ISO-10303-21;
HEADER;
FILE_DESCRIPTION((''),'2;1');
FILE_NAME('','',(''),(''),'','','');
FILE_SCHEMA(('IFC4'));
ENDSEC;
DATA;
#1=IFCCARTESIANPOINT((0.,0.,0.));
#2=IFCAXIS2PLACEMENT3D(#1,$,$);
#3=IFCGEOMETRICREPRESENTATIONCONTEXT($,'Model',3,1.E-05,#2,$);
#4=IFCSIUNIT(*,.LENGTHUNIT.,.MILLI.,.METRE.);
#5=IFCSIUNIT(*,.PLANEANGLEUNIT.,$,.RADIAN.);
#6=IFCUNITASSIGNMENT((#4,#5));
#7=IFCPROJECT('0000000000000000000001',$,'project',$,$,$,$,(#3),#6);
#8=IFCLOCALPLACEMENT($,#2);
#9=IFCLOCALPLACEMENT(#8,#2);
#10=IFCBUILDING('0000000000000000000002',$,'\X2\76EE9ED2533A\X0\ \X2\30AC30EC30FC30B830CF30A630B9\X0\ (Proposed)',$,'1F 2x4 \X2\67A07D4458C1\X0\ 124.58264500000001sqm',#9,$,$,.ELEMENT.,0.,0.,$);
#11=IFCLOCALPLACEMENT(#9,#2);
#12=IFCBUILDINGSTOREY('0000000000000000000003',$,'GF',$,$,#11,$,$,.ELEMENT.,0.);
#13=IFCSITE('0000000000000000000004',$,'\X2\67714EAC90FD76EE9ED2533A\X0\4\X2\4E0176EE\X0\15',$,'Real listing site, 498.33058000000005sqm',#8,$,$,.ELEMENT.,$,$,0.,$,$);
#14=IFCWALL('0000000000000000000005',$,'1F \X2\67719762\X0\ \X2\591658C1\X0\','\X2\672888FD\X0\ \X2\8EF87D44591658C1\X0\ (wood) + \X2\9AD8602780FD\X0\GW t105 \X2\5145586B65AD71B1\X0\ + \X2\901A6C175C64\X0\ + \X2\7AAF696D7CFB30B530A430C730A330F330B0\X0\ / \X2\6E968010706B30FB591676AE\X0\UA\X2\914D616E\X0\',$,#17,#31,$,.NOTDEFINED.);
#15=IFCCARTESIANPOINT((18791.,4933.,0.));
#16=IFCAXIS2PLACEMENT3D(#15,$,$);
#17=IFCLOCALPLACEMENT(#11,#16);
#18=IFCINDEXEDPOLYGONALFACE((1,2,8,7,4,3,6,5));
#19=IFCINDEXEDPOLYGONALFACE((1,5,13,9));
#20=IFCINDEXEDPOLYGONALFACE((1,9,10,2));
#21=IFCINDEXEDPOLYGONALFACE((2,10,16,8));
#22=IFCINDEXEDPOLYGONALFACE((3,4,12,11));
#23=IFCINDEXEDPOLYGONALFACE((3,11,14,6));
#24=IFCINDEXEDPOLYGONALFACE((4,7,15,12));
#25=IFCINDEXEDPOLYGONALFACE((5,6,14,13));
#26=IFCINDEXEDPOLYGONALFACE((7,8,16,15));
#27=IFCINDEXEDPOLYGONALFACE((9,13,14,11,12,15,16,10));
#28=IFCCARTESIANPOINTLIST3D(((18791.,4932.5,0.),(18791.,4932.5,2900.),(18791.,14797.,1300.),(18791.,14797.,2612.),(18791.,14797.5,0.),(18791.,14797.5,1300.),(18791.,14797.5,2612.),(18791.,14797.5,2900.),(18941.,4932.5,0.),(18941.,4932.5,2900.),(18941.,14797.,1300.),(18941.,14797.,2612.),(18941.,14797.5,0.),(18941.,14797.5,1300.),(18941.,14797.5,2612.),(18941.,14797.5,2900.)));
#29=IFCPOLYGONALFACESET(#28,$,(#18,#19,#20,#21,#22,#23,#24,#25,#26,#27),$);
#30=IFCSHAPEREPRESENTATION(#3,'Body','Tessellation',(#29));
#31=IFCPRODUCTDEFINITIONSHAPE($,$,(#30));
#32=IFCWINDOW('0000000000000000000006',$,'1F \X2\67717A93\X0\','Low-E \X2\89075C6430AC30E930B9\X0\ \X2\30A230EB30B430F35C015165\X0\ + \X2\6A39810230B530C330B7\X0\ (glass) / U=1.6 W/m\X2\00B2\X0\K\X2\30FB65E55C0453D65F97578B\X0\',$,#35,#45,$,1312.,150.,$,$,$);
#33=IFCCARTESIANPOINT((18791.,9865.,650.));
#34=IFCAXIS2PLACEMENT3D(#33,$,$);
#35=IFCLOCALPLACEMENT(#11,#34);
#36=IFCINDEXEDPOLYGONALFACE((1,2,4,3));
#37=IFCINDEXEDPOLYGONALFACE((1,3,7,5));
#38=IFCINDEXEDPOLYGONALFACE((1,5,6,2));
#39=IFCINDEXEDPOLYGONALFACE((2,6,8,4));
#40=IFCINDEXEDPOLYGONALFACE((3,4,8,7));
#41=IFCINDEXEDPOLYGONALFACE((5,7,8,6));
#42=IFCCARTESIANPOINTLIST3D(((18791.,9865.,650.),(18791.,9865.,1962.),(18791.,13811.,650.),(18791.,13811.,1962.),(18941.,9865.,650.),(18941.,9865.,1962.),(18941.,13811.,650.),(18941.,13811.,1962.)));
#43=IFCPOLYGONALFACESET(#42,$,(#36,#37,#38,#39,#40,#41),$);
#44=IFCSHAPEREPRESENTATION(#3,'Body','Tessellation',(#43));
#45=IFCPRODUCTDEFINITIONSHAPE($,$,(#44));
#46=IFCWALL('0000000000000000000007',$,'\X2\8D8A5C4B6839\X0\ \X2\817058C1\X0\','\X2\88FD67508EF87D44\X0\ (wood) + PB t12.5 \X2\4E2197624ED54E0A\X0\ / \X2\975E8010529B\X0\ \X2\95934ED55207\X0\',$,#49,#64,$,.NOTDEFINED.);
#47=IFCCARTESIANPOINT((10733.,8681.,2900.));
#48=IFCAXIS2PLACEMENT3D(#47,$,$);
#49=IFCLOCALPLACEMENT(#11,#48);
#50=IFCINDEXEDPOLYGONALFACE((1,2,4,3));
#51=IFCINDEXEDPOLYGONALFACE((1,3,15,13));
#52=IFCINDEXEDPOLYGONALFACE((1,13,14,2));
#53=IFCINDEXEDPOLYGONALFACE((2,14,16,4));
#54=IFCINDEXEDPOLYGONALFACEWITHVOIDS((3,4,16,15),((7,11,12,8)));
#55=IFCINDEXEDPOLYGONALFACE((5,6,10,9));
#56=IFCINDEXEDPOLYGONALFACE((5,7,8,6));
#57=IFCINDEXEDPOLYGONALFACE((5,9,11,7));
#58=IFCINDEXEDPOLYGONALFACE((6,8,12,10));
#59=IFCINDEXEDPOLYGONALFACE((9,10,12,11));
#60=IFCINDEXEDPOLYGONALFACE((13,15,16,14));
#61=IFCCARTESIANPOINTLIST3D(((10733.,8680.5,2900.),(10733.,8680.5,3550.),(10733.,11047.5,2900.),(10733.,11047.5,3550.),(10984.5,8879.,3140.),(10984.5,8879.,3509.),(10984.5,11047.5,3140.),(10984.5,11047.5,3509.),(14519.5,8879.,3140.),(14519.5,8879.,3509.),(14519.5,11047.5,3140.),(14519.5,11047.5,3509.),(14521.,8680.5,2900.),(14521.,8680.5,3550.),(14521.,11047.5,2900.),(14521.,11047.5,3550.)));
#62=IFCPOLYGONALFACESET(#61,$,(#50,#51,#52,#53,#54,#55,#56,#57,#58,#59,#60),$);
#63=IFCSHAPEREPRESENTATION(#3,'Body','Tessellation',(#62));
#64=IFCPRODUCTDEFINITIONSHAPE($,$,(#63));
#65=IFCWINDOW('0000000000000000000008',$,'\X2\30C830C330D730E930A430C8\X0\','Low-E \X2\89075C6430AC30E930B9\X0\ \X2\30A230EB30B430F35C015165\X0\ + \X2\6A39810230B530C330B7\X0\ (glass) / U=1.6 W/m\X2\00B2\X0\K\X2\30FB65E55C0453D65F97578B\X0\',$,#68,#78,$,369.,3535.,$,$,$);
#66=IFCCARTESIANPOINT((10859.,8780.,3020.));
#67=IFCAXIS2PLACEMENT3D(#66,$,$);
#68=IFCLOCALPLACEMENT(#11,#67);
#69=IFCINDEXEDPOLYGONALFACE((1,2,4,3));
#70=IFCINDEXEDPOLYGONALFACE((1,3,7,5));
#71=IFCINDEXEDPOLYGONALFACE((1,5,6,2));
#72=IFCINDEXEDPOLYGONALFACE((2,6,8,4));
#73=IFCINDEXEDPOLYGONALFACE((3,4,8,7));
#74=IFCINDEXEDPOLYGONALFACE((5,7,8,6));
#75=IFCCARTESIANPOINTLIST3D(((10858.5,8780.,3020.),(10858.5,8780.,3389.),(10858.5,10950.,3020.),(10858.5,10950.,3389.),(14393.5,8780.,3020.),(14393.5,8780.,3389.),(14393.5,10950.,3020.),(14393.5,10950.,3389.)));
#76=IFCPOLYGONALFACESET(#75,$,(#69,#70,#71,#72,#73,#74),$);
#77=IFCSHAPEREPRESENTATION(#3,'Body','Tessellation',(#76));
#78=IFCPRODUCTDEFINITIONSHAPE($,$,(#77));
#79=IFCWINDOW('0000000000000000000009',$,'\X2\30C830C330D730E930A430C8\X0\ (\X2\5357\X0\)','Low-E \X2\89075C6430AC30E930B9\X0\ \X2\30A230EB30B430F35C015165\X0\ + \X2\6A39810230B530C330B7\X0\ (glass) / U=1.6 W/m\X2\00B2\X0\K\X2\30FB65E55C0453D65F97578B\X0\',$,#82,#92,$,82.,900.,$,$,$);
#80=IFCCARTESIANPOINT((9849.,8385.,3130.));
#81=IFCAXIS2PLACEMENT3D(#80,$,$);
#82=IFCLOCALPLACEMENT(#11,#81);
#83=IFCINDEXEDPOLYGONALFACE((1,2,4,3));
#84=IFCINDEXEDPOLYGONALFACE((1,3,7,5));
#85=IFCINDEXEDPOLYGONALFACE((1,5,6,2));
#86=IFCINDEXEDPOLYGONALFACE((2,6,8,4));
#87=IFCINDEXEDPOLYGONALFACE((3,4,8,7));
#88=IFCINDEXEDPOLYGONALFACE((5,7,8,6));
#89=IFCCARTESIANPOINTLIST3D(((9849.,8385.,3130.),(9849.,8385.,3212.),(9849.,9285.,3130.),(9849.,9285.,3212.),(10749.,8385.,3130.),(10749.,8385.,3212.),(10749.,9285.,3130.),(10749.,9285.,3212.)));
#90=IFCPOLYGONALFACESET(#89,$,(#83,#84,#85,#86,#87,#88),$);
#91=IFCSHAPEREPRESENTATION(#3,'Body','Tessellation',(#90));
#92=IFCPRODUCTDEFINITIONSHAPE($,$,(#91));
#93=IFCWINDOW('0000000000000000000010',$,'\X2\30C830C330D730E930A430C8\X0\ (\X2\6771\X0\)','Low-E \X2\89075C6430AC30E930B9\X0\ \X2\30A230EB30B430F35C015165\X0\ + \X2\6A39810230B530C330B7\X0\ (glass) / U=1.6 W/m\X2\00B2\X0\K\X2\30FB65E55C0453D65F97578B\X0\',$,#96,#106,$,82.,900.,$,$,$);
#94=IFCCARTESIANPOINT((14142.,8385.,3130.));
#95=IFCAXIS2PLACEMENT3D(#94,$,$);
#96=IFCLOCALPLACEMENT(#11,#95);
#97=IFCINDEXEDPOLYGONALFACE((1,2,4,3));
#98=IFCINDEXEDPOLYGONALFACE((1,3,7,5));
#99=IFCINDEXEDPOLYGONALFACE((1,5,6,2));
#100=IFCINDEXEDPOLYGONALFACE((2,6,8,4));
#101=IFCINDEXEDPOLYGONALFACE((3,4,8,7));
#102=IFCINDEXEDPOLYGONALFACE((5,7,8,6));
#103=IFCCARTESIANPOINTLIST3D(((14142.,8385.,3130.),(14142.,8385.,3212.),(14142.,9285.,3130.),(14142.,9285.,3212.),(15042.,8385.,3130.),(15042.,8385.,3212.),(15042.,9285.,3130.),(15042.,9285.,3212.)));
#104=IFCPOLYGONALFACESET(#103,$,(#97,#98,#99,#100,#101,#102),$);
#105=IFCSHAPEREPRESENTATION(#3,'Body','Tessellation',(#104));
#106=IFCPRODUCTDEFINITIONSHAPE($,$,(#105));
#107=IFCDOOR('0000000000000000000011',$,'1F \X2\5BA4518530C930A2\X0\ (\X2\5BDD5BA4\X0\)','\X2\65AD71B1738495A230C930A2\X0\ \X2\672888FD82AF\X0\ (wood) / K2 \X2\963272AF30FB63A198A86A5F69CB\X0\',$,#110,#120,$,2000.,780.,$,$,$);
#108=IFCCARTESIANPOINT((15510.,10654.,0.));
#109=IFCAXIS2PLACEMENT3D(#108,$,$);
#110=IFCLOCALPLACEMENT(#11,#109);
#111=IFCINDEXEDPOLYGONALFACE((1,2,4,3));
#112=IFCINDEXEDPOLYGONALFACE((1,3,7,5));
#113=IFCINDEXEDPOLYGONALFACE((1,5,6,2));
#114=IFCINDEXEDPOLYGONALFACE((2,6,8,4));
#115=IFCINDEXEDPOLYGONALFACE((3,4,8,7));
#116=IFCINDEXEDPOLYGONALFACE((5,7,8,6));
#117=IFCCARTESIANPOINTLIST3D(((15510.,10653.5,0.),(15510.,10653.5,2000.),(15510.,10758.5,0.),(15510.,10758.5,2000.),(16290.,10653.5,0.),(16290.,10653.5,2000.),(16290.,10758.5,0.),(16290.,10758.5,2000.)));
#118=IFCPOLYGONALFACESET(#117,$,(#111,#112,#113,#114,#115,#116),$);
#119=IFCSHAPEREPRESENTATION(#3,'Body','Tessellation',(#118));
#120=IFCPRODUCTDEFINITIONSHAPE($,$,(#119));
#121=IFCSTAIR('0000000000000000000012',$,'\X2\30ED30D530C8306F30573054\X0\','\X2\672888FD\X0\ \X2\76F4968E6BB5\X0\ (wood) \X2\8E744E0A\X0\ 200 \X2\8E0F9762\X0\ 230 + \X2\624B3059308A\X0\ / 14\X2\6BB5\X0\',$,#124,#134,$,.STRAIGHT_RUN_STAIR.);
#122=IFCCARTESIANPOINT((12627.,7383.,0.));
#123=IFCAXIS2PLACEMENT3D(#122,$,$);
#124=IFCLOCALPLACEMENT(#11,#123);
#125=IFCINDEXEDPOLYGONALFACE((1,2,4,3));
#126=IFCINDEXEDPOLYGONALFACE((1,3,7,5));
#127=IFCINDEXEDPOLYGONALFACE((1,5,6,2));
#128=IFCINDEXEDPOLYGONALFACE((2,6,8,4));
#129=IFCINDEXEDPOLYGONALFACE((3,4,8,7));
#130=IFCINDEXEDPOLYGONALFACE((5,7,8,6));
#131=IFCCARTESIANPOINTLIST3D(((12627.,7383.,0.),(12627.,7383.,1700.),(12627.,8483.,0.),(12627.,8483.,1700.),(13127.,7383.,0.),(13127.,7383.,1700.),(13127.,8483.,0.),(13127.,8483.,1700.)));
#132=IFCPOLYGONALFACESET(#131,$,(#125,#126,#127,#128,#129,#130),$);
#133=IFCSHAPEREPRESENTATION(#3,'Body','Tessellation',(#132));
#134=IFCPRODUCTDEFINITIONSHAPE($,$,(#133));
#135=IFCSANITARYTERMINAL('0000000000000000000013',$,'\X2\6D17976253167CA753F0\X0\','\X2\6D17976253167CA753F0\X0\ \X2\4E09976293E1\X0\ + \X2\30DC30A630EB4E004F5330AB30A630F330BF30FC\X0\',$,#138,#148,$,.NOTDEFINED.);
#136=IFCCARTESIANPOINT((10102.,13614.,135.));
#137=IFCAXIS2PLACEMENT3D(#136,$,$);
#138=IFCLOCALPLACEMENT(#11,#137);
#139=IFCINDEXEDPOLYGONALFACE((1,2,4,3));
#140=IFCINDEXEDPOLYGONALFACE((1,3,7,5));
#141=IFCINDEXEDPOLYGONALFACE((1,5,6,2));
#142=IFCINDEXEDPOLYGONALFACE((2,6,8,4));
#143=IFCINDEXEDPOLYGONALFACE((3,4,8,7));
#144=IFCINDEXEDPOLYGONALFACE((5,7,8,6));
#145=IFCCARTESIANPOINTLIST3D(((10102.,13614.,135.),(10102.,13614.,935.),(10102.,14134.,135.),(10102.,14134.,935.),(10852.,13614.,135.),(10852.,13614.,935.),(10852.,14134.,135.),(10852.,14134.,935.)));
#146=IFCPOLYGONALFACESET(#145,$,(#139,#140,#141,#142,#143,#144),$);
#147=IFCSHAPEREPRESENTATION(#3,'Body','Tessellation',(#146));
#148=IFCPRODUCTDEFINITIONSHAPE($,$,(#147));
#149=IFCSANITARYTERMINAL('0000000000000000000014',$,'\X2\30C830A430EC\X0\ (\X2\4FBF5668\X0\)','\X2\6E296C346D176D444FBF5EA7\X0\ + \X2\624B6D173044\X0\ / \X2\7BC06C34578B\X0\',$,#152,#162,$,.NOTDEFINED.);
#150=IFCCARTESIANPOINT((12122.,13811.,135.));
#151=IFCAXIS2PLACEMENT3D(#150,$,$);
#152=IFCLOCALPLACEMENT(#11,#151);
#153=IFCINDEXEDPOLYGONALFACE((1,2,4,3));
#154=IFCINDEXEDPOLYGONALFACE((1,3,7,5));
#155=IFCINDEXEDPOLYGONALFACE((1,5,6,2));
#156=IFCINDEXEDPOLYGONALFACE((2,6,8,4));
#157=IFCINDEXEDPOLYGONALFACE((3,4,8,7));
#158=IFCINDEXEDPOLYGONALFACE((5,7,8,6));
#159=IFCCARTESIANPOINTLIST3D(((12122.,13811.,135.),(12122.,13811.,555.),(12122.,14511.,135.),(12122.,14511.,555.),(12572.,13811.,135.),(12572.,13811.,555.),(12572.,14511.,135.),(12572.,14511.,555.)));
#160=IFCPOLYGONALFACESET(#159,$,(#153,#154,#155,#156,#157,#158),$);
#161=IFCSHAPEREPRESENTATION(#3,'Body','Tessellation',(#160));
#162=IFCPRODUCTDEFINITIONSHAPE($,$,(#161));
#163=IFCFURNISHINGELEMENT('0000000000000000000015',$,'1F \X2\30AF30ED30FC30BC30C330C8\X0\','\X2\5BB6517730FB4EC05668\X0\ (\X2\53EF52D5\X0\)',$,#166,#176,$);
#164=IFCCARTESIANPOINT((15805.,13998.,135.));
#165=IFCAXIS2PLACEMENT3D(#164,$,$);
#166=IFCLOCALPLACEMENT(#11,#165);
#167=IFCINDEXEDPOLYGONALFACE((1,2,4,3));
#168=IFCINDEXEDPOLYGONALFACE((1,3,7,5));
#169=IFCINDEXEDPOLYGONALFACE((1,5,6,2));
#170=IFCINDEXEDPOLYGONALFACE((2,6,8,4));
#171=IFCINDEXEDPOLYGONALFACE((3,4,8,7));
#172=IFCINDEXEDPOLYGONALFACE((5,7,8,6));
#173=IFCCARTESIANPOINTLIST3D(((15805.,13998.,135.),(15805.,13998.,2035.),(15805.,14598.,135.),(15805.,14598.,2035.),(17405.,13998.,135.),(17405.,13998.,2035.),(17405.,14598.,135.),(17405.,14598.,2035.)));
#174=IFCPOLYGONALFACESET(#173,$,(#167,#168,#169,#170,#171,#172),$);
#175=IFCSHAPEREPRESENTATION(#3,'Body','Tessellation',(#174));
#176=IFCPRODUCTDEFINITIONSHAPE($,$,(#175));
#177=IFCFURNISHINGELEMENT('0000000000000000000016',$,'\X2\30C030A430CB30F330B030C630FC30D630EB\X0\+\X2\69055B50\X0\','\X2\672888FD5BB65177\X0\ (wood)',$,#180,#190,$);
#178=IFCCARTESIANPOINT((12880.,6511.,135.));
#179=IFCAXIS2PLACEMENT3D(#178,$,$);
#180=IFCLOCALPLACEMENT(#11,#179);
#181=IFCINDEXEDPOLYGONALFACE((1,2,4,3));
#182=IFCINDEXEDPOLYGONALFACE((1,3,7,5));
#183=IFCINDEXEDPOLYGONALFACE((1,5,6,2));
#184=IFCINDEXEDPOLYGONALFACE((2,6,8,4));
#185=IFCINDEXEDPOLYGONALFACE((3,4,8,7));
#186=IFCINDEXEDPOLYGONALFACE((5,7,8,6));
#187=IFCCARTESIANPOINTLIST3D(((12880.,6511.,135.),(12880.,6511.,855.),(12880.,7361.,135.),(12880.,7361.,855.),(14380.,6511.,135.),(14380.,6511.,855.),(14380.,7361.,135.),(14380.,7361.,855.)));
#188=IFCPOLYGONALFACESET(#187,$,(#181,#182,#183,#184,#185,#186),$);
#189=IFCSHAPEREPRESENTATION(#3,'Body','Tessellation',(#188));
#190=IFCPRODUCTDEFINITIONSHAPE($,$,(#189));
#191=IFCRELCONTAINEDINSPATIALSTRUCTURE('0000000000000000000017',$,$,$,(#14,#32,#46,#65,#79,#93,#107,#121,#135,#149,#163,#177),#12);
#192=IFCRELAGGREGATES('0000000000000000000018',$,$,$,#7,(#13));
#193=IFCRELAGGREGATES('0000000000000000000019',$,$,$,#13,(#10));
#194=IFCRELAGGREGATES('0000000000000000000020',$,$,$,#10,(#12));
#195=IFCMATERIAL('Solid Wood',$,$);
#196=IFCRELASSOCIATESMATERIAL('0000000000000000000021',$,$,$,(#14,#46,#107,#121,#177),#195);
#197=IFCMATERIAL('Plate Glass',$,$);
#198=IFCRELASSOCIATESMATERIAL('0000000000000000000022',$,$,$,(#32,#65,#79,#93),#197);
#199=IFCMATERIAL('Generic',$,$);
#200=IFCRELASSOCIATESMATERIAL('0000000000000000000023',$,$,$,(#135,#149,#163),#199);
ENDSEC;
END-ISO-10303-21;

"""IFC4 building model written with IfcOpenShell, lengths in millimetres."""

from ifc_helpers import new_model, si_unit, frame, frame_2d, origin, place, context, project, spatial, rectangle, extrude, material, element, fill, save


model = new_model("IFC4")

# Units and contexts
model_context = context("Model", 3, precision=1e-05, world=origin())
ifc_project = project(units=[si_unit("LENGTHUNIT", "METRE", prefix="MILLI"), si_unit("PLANEANGLEUNIT", "RADIAN")], contexts=[model_context])

# Site, building, storey
site_placement = place(None, origin())
site = spatial("IfcSite", under=ifc_project, at=site_placement, Name="東京都目黒区4丁目15", ObjectType="Real listing site, 498.33058000000005sqm", CompositionType="ELEMENT", RefElevation=0.0)
building_placement = place(site_placement, origin())
building = spatial("IfcBuilding", under=site, at=building_placement, Name="目黒区 ガレージハウス (Proposed)", ObjectType="1F 2x4 枠組壁 124.58264500000001sqm", CompositionType="ELEMENT", ElevationOfRefHeight=0.0, ElevationOfTerrain=0.0)
storey_placement = place(building_placement, origin())
storey = spatial("IfcBuildingStorey", under=building, at=storey_placement, Name="GF", CompositionType="ELEMENT", Elevation=0.0)

# Wall, opening, window
ifc_material_1 = material(Name="Solid Wood")
wall_1_placement = place(storey_placement, frame((18791.0, 4933.0, 0.0)))
wall_1 = element("IfcWall", 1, at=wall_1_placement, inside=storey, material=ifc_material_1, Name="1F 東面 外壁", Description="木製 軸組外壁 (wood) + 高性能GW t105 充填断熱 + 通気層 + 窯業系サイディング / 準耐火・外皮UA配慮", PredefinedType="NOTDEFINED", context=model_context, shape_type="SweptSolid", body=[
    extrude(rectangle(XDim=150.0, YDim=9865.0, at=frame_2d((75.0, 4932.0))), frame((18791.0, 4933.0, 0.0)), (0.0, 0.0, 1.0), 2900.0),
])
opening_1_placement = place(storey_placement, frame((18791.0, 9865.0, 650.0)))
opening_1 = element("IfcOpeningElement", 2, at=opening_1_placement, cuts=wall_1, PredefinedType="NOTDEFINED", context=model_context, shape_type="SweptSolid", body=[
    extrude(rectangle(XDim=150.0, YDim=3946.0, at=frame_2d((75.0, 1973.0))), frame((18791.0, 9865.0, 650.0)), (0.0, 0.0, 1.0), 1312.0),
])
ifc_material_2 = material(Name="Plate Glass")
window_1_placement = place(storey_placement, frame((18791.0, 9865.0, 650.0)))
window_1 = element("IfcWindow", 3, at=window_1_placement, inside=storey, material=ifc_material_2, Name="1F 東窓", Description="Low-E 複層ガラス アルゴン封入 + 樹脂サッシ (glass) / U=1.6 W/m²K・日射取得型", OverallHeight=1312.0, OverallWidth=150.0, context=model_context, shape_type="SweptSolid", body=[
    extrude(rectangle(XDim=150.0, YDim=3946.0, at=frame_2d((75.0, 1973.0))), frame((18791.0, 9865.0, 650.0)), (0.0, 0.0, 1.0), 1312.0),
])
fill(opening_1, window_1)

# Wall, openings, windows
wall_2_placement = place(storey_placement, frame((10733.0, 8681.0, 2900.0)))
wall_2 = element("IfcWall", 4, at=wall_2_placement, inside=storey, material=ifc_material_1, Name="越屋根 腰壁", Description="製材軸組 (wood) + PB t12.5 両面仕上 / 非耐力 間仕切", PredefinedType="NOTDEFINED", context=model_context, shape_type="SweptSolid", body=[
    extrude(rectangle(XDim=3788.0, YDim=2367.0, at=frame_2d((1894.0, 1183.0))), frame((10733.0, 8681.0, 2900.0)), (0.0, 0.0, 1.0), 650.0),
])
opening_2_placement = place(storey_placement, frame((10859.0, 8780.0, 3020.0)))
opening_2 = element("IfcOpeningElement", 5, at=opening_2_placement, cuts=wall_2, PredefinedType="NOTDEFINED", context=model_context, shape_type="SweptSolid", body=[
    extrude(rectangle(XDim=3535.0, YDim=2170.0, at=frame_2d((1767.0, 1085.0))), frame((10859.0, 8780.0, 3020.0)), (0.0, 0.0, 1.0), 369.0),
])
opening_3_placement = place(storey_placement, frame((9849.0, 8385.0, 3130.0)))
opening_3 = element("IfcOpeningElement", 6, at=opening_3_placement, cuts=wall_2, PredefinedType="NOTDEFINED", context=model_context, shape_type="SweptSolid", body=[
    extrude(rectangle(XDim=900.0, YDim=900.0, at=frame_2d((450.0, 450.0))), frame((9849.0, 8385.0, 3130.0)), (0.0, 0.0, 1.0), 82.0),
])
opening_4_placement = place(storey_placement, frame((14142.0, 8385.0, 3130.0)))
opening_4 = element("IfcOpeningElement", 7, at=opening_4_placement, cuts=wall_2, PredefinedType="NOTDEFINED", context=model_context, shape_type="SweptSolid", body=[
    extrude(rectangle(XDim=900.0, YDim=900.0, at=frame_2d((450.0, 450.0))), frame((14142.0, 8385.0, 3130.0)), (0.0, 0.0, 1.0), 82.0),
])
window_2_placement = place(storey_placement, frame((10859.0, 8780.0, 3020.0)))
window_2 = element("IfcWindow", 8, at=window_2_placement, inside=storey, material=ifc_material_2, Name="トップライト", Description="Low-E 複層ガラス アルゴン封入 + 樹脂サッシ (glass) / U=1.6 W/m²K・日射取得型", OverallHeight=369.0, OverallWidth=3535.0, context=model_context, shape_type="SweptSolid", body=[
    extrude(rectangle(XDim=3535.0, YDim=2170.0, at=frame_2d((1767.0, 1085.0))), frame((10859.0, 8780.0, 3020.0)), (0.0, 0.0, 1.0), 369.0),
])
fill(opening_2, window_2)
window_3_placement = place(storey_placement, frame((9849.0, 8385.0, 3130.0)))
window_3 = element("IfcWindow", 9, at=window_3_placement, inside=storey, material=ifc_material_2, Name="トップライト (南)", Description="Low-E 複層ガラス アルゴン封入 + 樹脂サッシ (glass) / U=1.6 W/m²K・日射取得型", OverallHeight=82.0, OverallWidth=900.0, context=model_context, shape_type="SweptSolid", body=[
    extrude(rectangle(XDim=900.0, YDim=900.0, at=frame_2d((450.0, 450.0))), frame((9849.0, 8385.0, 3130.0)), (0.0, 0.0, 1.0), 82.0),
])
fill(opening_3, window_3)
window_4_placement = place(storey_placement, frame((14142.0, 8385.0, 3130.0)))
window_4 = element("IfcWindow", 10, at=window_4_placement, inside=storey, material=ifc_material_2, Name="トップライト (東)", Description="Low-E 複層ガラス アルゴン封入 + 樹脂サッシ (glass) / U=1.6 W/m²K・日射取得型", OverallHeight=82.0, OverallWidth=900.0, context=model_context, shape_type="SweptSolid", body=[
    extrude(rectangle(XDim=900.0, YDim=900.0, at=frame_2d((450.0, 450.0))), frame((14142.0, 8385.0, 3130.0)), (0.0, 0.0, 1.0), 82.0),
])
fill(opening_4, window_4)

# Door
door_placement = place(storey_placement, frame((15510.0, 10654.0, 0.0)))
element("IfcDoor", 11, at=door_placement, inside=storey, material=ifc_material_1, Name="1F 室内ドア (寝室)", Description="断熱玄関ドア 木製芯 (wood) / K2 防犯・採風機構", OverallHeight=2000.0, OverallWidth=780.0, context=model_context, shape_type="SweptSolid", body=[
    extrude(rectangle(XDim=780.0, YDim=105.0, at=frame_2d((390.0, 52.0))), frame((15510.0, 10654.0, 0.0)), (0.0, 0.0, 1.0), 2000.0),
])

# Stair
stair_placement = place(storey_placement, frame((12627.0, 7383.0, 0.0)))
element("IfcStair", 12, at=stair_placement, inside=storey, material=ifc_material_1, Name="ロフトはしご", Description="木製 直階段 (wood) 蹴上 200 踏面 230 + 手すり / 14段", PredefinedType="STRAIGHT_RUN_STAIR", context=model_context, shape_type="SweptSolid", body=[
    extrude(rectangle(XDim=500.0, YDim=1100.0, at=frame_2d((250.0, 550.0))), frame((12627.0, 7383.0, 0.0)), (0.0, 0.0, 1.0), 1700.0),
])

# Sanitary terminals
ifc_material_3 = material(Name="Generic")
sanitary_terminal_1_placement = place(storey_placement, frame((10102.0, 13614.0, 135.0)))
element("IfcSanitaryTerminal", 13, at=sanitary_terminal_1_placement, inside=storey, material=ifc_material_3, Name="洗面化粧台", Description="洗面化粧台 三面鏡 + ボウル一体カウンター", PredefinedType="NOTDEFINED", context=model_context, shape_type="SweptSolid", body=[
    extrude(rectangle(XDim=750.0, YDim=520.0, at=frame_2d((375.0, 260.0))), frame((10102.0, 13614.0, 135.0)), (0.0, 0.0, 1.0), 800.0),
])
sanitary_terminal_2_placement = place(storey_placement, frame((12122.0, 13811.0, 135.0)))
element("IfcSanitaryTerminal", 14, at=sanitary_terminal_2_placement, inside=storey, material=ifc_material_3, Name="トイレ (便器)", Description="温水洗浄便座 + 手洗い / 節水型", PredefinedType="NOTDEFINED", context=model_context, shape_type="SweptSolid", body=[
    extrude(rectangle(XDim=450.0, YDim=700.0, at=frame_2d((225.0, 350.0))), frame((12122.0, 13811.0, 135.0)), (0.0, 0.0, 1.0), 420.0),
])

# Furnishing elements
furnishing_1_placement = place(storey_placement, frame((15805.0, 13998.0, 135.0)))
element("IfcFurnishingElement", 15, at=furnishing_1_placement, inside=storey, material=ifc_material_3, Name="1F クローゼット", Description="家具・什器 (可動)", context=model_context, shape_type="SweptSolid", body=[
    extrude(rectangle(XDim=1600.0, YDim=600.0, at=frame_2d((800.0, 300.0))), frame((15805.0, 13998.0, 135.0)), (0.0, 0.0, 1.0), 1900.0),
])
furnishing_2_placement = place(storey_placement, frame((12880.0, 6511.0, 135.0)))
element("IfcFurnishingElement", 16, at=furnishing_2_placement, inside=storey, material=ifc_material_1, Name="ダイニングテーブル+椅子", Description="木製家具 (wood)", context=model_context, shape_type="SweptSolid", body=[
    extrude(rectangle(XDim=1500.0, YDim=850.0, at=frame_2d((750.0, 425.0))), frame((12880.0, 6511.0, 135.0)), (0.0, 0.0, 1.0), 720.0),
])

save(model, "model.ifc")
